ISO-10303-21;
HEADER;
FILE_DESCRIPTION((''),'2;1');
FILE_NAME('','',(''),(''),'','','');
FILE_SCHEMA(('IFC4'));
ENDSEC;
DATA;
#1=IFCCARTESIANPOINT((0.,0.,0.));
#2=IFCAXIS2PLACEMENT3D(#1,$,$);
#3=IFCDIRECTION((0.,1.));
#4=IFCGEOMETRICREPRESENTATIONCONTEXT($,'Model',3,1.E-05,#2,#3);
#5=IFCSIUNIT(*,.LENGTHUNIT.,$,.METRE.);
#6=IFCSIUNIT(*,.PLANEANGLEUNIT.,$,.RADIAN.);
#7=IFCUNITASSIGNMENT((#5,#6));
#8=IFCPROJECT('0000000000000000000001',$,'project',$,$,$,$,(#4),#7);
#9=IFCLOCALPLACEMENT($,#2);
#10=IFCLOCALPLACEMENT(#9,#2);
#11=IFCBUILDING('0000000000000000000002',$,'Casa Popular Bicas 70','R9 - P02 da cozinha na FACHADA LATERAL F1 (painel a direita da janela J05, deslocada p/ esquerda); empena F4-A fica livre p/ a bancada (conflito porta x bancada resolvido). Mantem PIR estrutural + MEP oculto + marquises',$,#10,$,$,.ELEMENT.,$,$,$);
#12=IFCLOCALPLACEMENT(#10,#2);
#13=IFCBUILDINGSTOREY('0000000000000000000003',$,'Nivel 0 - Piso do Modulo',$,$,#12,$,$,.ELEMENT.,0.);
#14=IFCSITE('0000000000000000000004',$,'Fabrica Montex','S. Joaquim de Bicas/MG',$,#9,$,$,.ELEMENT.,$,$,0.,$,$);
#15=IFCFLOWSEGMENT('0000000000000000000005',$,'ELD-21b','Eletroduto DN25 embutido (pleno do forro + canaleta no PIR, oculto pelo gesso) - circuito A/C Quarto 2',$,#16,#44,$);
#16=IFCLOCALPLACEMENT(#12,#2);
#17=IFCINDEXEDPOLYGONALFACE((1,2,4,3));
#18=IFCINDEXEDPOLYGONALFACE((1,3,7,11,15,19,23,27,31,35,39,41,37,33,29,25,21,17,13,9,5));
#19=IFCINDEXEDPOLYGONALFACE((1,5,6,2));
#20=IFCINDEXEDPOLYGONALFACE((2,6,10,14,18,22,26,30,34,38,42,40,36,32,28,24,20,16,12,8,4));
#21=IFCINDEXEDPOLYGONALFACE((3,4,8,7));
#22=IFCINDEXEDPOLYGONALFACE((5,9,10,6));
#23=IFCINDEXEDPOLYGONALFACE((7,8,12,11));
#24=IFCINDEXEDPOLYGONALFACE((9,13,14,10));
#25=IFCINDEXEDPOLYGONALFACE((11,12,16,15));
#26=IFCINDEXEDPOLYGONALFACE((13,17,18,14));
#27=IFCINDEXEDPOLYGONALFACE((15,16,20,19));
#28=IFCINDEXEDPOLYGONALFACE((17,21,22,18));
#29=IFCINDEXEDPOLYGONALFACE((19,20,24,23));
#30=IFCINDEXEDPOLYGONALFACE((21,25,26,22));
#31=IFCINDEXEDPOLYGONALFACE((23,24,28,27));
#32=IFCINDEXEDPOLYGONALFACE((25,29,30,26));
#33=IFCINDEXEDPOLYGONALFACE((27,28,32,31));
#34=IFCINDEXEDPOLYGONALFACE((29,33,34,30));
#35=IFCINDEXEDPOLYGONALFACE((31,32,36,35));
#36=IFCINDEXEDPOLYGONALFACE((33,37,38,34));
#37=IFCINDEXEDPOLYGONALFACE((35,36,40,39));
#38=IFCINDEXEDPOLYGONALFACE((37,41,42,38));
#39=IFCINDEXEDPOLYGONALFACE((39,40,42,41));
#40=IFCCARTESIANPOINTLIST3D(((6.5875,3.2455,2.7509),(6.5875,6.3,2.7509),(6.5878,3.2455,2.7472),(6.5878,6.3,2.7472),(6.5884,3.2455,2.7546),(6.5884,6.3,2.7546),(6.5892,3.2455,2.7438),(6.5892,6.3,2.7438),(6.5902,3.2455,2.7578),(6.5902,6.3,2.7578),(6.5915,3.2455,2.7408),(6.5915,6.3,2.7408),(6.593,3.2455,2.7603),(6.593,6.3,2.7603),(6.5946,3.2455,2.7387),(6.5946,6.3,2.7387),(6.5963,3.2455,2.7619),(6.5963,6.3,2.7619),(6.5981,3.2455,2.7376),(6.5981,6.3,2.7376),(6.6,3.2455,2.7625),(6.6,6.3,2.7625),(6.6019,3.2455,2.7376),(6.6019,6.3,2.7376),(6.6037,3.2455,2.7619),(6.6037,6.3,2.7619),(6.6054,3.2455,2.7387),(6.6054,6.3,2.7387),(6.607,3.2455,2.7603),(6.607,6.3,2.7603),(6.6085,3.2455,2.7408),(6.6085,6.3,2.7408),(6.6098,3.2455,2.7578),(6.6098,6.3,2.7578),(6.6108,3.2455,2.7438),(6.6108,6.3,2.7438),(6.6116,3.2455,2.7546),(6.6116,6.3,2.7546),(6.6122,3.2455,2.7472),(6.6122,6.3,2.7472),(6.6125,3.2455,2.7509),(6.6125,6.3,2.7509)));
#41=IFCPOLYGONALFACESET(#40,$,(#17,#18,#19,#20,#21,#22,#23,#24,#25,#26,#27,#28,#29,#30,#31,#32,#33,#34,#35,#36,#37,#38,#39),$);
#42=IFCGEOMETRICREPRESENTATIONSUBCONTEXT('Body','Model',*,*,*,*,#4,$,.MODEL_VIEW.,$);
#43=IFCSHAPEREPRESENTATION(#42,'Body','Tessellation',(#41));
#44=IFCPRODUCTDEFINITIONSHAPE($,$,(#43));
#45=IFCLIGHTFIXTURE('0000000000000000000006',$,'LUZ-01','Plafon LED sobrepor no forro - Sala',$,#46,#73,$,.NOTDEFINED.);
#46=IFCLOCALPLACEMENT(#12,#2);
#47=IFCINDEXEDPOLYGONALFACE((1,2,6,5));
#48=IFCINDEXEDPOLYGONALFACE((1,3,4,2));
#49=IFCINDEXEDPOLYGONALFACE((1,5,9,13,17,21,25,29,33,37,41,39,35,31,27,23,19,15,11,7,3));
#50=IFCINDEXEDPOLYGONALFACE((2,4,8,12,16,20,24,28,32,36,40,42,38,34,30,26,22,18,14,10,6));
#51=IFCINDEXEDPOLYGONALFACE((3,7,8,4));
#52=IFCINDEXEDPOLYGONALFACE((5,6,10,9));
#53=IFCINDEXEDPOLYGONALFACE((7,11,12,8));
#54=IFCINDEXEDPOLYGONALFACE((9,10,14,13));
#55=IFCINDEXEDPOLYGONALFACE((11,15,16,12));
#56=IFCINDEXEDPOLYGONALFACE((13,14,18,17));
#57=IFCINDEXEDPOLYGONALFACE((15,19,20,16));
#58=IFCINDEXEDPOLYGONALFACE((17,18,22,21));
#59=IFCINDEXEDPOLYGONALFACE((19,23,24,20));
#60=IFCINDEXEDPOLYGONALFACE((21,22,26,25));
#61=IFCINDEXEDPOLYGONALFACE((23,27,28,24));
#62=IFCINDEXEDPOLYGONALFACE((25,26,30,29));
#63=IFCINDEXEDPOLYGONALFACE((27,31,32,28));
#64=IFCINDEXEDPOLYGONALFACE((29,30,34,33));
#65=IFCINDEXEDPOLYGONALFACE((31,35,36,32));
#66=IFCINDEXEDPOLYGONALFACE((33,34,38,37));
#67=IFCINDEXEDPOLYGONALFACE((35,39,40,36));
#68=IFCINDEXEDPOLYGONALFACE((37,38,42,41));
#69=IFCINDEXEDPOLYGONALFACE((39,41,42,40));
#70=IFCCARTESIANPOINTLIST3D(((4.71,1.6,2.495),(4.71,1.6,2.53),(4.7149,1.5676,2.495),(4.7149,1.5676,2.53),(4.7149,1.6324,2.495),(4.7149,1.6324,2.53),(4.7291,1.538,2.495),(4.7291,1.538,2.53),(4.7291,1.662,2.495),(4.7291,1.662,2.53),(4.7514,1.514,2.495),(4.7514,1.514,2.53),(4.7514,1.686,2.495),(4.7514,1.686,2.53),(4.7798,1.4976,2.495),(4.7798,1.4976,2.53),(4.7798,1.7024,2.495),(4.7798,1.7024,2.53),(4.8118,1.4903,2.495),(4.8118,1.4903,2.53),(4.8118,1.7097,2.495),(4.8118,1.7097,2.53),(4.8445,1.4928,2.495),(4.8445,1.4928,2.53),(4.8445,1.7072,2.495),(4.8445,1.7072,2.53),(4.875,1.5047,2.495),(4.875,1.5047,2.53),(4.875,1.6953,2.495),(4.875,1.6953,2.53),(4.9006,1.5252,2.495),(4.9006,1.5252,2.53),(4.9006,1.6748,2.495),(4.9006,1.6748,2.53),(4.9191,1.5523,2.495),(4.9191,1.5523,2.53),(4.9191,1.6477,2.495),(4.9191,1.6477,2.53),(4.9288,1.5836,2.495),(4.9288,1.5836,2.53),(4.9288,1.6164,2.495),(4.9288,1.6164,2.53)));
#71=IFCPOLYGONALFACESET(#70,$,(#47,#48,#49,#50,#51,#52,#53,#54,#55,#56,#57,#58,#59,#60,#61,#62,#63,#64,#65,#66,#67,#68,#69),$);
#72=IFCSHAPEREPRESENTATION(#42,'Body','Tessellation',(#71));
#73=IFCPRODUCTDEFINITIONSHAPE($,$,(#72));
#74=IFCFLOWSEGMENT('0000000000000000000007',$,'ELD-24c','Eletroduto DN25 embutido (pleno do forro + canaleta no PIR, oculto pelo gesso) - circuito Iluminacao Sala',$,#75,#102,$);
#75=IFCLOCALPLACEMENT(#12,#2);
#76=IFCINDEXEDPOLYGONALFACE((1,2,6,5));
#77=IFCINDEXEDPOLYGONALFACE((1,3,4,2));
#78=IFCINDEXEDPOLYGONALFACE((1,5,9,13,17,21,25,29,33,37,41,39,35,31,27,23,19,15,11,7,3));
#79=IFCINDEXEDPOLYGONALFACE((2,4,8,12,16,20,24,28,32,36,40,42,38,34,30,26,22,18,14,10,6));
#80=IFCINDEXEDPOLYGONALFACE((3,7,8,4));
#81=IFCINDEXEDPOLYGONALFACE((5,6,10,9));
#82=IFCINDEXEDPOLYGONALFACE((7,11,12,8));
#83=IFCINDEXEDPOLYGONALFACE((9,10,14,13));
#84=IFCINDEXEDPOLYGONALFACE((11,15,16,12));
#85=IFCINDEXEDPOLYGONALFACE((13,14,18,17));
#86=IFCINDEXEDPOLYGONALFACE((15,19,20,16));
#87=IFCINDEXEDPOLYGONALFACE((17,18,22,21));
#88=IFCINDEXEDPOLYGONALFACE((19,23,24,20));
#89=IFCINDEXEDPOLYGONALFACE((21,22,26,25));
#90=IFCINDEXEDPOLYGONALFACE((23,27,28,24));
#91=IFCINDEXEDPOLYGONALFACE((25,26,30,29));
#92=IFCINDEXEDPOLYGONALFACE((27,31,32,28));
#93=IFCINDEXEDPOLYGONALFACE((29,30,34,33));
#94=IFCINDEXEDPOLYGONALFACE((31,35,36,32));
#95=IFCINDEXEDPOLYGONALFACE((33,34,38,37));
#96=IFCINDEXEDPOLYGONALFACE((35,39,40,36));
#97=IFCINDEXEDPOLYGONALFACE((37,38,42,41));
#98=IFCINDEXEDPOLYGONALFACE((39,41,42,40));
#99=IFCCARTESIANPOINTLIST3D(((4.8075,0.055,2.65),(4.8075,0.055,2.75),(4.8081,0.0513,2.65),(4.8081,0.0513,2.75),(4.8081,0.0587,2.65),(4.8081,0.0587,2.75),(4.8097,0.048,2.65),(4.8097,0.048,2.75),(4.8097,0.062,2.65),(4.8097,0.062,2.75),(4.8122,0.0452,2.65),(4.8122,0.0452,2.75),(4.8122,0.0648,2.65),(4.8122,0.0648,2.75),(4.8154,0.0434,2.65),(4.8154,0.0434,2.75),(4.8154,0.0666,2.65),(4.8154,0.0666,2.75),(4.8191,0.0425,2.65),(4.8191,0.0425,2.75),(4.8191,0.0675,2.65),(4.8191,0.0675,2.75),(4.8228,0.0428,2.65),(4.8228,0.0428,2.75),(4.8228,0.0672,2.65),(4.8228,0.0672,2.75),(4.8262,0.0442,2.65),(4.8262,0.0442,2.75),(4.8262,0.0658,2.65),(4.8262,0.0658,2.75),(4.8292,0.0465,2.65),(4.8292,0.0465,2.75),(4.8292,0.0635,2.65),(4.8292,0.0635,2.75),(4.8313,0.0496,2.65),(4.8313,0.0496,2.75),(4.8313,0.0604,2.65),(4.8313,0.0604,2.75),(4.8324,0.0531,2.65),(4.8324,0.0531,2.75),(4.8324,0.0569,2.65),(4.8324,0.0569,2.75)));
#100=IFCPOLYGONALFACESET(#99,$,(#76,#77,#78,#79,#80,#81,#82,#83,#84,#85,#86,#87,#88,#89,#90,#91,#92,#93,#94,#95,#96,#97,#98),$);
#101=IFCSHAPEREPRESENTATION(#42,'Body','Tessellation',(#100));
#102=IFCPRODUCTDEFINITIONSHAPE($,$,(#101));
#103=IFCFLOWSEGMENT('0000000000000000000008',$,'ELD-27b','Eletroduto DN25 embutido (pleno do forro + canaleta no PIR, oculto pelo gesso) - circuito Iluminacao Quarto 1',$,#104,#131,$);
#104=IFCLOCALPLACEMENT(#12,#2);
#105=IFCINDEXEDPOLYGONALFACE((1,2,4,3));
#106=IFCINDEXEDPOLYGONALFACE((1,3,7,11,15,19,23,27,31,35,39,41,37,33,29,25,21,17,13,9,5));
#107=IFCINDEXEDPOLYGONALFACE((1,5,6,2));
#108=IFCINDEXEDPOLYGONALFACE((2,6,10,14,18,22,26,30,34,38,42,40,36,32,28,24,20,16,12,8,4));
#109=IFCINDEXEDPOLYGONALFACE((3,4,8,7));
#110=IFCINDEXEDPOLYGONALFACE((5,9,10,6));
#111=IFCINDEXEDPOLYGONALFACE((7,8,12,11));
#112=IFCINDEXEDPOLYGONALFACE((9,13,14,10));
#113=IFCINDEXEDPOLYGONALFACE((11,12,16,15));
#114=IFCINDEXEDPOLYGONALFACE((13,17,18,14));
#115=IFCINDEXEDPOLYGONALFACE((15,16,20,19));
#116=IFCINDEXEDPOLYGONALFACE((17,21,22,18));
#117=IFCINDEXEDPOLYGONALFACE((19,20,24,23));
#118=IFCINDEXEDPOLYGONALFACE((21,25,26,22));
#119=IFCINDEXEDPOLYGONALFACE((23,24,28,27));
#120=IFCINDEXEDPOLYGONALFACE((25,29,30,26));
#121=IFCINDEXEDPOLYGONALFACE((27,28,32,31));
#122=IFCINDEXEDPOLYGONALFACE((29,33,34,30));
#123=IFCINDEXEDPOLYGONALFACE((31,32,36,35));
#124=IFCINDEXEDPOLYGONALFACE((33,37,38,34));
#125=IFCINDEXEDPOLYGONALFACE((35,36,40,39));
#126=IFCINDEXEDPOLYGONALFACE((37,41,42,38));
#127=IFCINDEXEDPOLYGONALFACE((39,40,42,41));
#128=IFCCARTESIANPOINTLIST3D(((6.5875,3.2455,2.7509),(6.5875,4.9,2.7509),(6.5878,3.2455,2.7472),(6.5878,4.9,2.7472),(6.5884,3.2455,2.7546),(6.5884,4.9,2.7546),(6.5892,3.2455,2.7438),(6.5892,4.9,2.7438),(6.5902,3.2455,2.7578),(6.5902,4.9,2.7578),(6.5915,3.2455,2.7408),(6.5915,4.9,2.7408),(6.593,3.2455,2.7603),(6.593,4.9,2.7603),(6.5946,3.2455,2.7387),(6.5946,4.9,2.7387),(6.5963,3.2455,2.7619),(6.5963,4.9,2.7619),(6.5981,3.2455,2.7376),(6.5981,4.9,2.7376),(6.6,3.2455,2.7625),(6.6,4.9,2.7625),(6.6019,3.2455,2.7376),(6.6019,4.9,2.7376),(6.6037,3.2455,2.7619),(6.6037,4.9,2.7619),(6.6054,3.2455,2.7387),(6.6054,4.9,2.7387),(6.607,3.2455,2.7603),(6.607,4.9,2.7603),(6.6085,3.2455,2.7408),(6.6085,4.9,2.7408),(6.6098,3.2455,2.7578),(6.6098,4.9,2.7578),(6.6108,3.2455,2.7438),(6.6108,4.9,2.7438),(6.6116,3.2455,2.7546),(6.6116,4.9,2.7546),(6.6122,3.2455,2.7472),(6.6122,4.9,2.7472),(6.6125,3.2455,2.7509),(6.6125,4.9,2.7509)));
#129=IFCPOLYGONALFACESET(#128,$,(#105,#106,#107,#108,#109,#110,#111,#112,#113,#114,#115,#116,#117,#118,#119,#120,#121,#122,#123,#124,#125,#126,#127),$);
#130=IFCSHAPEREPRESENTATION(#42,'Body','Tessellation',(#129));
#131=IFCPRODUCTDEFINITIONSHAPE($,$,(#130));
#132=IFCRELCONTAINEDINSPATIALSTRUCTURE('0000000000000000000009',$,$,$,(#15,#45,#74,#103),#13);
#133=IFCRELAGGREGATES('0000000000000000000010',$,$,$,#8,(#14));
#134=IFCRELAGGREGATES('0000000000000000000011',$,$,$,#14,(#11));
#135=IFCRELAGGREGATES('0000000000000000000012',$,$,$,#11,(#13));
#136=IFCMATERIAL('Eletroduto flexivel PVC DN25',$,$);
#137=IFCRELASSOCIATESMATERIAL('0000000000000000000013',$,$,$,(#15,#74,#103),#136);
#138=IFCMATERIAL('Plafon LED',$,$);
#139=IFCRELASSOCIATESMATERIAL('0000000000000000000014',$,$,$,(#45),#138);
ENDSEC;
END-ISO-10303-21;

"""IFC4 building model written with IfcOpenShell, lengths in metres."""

from ifc_helpers import new_model, si_unit, direction, frame, origin, origin_2d, place, context, subcontext, project, spatial, circle, extrude, material, element, save


model = new_model("IFC4")

# Units and contexts
model_context = context("Model", 3, precision=1e-05, world=origin(), true_north=direction((0.0, 1.0)))
body_context = subcontext(model_context, "Body", "Model", "MODEL_VIEW")
ifc_project = project(units=[si_unit("LENGTHUNIT", "METRE"), si_unit("PLANEANGLEUNIT", "RADIAN")], contexts=[model_context])

# Site, building, storey
site_placement = place(None, origin())
site = spatial("IfcSite", under=ifc_project, at=site_placement, Name="Fabrica Montex", Description="S. Joaquim de Bicas/MG", CompositionType="ELEMENT", RefElevation=0.0)
building_placement = place(site_placement, origin())
building = spatial("IfcBuilding", under=site, at=building_placement, Name="Casa Popular Bicas 70", Description="R9 - P02 da cozinha na FACHADA LATERAL F1 (painel a direita da janela J05, deslocada p/ esquerda); empena F4-A fica livre p/ a bancada (conflito porta x bancada resolvido). Mantem PIR estrutural + MEP oculto + marquises", CompositionType="ELEMENT")
storey_placement = place(building_placement, origin())
storey = spatial("IfcBuildingStorey", under=building, at=storey_placement, Name="Nivel 0 - Piso do Modulo", CompositionType="ELEMENT", Elevation=0.0)

# Shared definitions
ifc_material_1 = material(Name="Eletroduto flexivel PVC DN25")

# Flow segment
flow_segment_1_placement = place(storey_placement, frame((6.6, 3.2455, 2.75), z_axis=(0.0, 1.0, 0.0), x_axis=(0.0, 0.0, 1.0)))
element("IfcFlowSegment", 1, at=flow_segment_1_placement, inside=storey, material=ifc_material_1, Name="ELD-21b", Description="Eletroduto DN25 embutido (pleno do forro + canaleta no PIR, oculto pelo gesso) - circuito A/C Quarto 2", context=body_context, shape_type="SweptSolid", body=[
    extrude(circle(Radius=0.0125, at=origin_2d()), origin(), (0.0, 0.0, 1.0), 3.0545),
])

# Light fixture
ifc_material_2 = material(Name="Plafon LED")
light_fixture_placement = place(None, frame((4.82, 1.6, 2.495), z_axis=(0.0, 0.0, 1.0), x_axis=(-1.0, 0.0, 0.0)))
element("IfcLightFixture", 2, at=light_fixture_placement, inside=storey, material=ifc_material_2, Name="LUZ-01", Description="Plafon LED sobrepor no forro - Sala", PredefinedType="NOTDEFINED", context=body_context, shape_type="SweptSolid", body=[
    extrude(circle(Radius=0.11, at=origin_2d()), origin(), (0.0, 0.0, 1.0), 0.035),
])

# Flow segments
flow_segment_2_placement = place(None, frame((4.82, 0.055, 2.75), z_axis=(0.0, 0.0, -1.0), x_axis=(-1.0, 0.0, 0.0)))
element("IfcFlowSegment", 3, at=flow_segment_2_placement, inside=storey, material=ifc_material_1, Name="ELD-24c", Description="Eletroduto DN25 embutido (pleno do forro + canaleta no PIR, oculto pelo gesso) - circuito Iluminacao Sala", context=body_context, shape_type="SweptSolid", body=[
    extrude(circle(Radius=0.0125, at=origin_2d()), origin(), (0.0, 0.0, 1.0), 0.1),
])
for number, where, z_axis, x_axis, name in (
    (4, (6.6, 3.2455, 2.75), (0.0, 1.0, 0.0), (0.0, 0.0, 1.0), "ELD-27b"),
):
    element("IfcFlowSegment", number, at=place(storey_placement, frame(where, z_axis=z_axis, x_axis=x_axis)), inside=storey, material=ifc_material_1, Name=name, Description="Eletroduto DN25 embutido (pleno do forro + canaleta no PIR, oculto pelo gesso) - circuito Iluminacao Quarto 1", context=body_context, shape_type="SweptSolid", body=[
        extrude(circle(Radius=0.0125, at=origin_2d()), origin(), (0.0, 0.0, 1.0), 1.6545),
    ])

save(model, "model.ifc")
